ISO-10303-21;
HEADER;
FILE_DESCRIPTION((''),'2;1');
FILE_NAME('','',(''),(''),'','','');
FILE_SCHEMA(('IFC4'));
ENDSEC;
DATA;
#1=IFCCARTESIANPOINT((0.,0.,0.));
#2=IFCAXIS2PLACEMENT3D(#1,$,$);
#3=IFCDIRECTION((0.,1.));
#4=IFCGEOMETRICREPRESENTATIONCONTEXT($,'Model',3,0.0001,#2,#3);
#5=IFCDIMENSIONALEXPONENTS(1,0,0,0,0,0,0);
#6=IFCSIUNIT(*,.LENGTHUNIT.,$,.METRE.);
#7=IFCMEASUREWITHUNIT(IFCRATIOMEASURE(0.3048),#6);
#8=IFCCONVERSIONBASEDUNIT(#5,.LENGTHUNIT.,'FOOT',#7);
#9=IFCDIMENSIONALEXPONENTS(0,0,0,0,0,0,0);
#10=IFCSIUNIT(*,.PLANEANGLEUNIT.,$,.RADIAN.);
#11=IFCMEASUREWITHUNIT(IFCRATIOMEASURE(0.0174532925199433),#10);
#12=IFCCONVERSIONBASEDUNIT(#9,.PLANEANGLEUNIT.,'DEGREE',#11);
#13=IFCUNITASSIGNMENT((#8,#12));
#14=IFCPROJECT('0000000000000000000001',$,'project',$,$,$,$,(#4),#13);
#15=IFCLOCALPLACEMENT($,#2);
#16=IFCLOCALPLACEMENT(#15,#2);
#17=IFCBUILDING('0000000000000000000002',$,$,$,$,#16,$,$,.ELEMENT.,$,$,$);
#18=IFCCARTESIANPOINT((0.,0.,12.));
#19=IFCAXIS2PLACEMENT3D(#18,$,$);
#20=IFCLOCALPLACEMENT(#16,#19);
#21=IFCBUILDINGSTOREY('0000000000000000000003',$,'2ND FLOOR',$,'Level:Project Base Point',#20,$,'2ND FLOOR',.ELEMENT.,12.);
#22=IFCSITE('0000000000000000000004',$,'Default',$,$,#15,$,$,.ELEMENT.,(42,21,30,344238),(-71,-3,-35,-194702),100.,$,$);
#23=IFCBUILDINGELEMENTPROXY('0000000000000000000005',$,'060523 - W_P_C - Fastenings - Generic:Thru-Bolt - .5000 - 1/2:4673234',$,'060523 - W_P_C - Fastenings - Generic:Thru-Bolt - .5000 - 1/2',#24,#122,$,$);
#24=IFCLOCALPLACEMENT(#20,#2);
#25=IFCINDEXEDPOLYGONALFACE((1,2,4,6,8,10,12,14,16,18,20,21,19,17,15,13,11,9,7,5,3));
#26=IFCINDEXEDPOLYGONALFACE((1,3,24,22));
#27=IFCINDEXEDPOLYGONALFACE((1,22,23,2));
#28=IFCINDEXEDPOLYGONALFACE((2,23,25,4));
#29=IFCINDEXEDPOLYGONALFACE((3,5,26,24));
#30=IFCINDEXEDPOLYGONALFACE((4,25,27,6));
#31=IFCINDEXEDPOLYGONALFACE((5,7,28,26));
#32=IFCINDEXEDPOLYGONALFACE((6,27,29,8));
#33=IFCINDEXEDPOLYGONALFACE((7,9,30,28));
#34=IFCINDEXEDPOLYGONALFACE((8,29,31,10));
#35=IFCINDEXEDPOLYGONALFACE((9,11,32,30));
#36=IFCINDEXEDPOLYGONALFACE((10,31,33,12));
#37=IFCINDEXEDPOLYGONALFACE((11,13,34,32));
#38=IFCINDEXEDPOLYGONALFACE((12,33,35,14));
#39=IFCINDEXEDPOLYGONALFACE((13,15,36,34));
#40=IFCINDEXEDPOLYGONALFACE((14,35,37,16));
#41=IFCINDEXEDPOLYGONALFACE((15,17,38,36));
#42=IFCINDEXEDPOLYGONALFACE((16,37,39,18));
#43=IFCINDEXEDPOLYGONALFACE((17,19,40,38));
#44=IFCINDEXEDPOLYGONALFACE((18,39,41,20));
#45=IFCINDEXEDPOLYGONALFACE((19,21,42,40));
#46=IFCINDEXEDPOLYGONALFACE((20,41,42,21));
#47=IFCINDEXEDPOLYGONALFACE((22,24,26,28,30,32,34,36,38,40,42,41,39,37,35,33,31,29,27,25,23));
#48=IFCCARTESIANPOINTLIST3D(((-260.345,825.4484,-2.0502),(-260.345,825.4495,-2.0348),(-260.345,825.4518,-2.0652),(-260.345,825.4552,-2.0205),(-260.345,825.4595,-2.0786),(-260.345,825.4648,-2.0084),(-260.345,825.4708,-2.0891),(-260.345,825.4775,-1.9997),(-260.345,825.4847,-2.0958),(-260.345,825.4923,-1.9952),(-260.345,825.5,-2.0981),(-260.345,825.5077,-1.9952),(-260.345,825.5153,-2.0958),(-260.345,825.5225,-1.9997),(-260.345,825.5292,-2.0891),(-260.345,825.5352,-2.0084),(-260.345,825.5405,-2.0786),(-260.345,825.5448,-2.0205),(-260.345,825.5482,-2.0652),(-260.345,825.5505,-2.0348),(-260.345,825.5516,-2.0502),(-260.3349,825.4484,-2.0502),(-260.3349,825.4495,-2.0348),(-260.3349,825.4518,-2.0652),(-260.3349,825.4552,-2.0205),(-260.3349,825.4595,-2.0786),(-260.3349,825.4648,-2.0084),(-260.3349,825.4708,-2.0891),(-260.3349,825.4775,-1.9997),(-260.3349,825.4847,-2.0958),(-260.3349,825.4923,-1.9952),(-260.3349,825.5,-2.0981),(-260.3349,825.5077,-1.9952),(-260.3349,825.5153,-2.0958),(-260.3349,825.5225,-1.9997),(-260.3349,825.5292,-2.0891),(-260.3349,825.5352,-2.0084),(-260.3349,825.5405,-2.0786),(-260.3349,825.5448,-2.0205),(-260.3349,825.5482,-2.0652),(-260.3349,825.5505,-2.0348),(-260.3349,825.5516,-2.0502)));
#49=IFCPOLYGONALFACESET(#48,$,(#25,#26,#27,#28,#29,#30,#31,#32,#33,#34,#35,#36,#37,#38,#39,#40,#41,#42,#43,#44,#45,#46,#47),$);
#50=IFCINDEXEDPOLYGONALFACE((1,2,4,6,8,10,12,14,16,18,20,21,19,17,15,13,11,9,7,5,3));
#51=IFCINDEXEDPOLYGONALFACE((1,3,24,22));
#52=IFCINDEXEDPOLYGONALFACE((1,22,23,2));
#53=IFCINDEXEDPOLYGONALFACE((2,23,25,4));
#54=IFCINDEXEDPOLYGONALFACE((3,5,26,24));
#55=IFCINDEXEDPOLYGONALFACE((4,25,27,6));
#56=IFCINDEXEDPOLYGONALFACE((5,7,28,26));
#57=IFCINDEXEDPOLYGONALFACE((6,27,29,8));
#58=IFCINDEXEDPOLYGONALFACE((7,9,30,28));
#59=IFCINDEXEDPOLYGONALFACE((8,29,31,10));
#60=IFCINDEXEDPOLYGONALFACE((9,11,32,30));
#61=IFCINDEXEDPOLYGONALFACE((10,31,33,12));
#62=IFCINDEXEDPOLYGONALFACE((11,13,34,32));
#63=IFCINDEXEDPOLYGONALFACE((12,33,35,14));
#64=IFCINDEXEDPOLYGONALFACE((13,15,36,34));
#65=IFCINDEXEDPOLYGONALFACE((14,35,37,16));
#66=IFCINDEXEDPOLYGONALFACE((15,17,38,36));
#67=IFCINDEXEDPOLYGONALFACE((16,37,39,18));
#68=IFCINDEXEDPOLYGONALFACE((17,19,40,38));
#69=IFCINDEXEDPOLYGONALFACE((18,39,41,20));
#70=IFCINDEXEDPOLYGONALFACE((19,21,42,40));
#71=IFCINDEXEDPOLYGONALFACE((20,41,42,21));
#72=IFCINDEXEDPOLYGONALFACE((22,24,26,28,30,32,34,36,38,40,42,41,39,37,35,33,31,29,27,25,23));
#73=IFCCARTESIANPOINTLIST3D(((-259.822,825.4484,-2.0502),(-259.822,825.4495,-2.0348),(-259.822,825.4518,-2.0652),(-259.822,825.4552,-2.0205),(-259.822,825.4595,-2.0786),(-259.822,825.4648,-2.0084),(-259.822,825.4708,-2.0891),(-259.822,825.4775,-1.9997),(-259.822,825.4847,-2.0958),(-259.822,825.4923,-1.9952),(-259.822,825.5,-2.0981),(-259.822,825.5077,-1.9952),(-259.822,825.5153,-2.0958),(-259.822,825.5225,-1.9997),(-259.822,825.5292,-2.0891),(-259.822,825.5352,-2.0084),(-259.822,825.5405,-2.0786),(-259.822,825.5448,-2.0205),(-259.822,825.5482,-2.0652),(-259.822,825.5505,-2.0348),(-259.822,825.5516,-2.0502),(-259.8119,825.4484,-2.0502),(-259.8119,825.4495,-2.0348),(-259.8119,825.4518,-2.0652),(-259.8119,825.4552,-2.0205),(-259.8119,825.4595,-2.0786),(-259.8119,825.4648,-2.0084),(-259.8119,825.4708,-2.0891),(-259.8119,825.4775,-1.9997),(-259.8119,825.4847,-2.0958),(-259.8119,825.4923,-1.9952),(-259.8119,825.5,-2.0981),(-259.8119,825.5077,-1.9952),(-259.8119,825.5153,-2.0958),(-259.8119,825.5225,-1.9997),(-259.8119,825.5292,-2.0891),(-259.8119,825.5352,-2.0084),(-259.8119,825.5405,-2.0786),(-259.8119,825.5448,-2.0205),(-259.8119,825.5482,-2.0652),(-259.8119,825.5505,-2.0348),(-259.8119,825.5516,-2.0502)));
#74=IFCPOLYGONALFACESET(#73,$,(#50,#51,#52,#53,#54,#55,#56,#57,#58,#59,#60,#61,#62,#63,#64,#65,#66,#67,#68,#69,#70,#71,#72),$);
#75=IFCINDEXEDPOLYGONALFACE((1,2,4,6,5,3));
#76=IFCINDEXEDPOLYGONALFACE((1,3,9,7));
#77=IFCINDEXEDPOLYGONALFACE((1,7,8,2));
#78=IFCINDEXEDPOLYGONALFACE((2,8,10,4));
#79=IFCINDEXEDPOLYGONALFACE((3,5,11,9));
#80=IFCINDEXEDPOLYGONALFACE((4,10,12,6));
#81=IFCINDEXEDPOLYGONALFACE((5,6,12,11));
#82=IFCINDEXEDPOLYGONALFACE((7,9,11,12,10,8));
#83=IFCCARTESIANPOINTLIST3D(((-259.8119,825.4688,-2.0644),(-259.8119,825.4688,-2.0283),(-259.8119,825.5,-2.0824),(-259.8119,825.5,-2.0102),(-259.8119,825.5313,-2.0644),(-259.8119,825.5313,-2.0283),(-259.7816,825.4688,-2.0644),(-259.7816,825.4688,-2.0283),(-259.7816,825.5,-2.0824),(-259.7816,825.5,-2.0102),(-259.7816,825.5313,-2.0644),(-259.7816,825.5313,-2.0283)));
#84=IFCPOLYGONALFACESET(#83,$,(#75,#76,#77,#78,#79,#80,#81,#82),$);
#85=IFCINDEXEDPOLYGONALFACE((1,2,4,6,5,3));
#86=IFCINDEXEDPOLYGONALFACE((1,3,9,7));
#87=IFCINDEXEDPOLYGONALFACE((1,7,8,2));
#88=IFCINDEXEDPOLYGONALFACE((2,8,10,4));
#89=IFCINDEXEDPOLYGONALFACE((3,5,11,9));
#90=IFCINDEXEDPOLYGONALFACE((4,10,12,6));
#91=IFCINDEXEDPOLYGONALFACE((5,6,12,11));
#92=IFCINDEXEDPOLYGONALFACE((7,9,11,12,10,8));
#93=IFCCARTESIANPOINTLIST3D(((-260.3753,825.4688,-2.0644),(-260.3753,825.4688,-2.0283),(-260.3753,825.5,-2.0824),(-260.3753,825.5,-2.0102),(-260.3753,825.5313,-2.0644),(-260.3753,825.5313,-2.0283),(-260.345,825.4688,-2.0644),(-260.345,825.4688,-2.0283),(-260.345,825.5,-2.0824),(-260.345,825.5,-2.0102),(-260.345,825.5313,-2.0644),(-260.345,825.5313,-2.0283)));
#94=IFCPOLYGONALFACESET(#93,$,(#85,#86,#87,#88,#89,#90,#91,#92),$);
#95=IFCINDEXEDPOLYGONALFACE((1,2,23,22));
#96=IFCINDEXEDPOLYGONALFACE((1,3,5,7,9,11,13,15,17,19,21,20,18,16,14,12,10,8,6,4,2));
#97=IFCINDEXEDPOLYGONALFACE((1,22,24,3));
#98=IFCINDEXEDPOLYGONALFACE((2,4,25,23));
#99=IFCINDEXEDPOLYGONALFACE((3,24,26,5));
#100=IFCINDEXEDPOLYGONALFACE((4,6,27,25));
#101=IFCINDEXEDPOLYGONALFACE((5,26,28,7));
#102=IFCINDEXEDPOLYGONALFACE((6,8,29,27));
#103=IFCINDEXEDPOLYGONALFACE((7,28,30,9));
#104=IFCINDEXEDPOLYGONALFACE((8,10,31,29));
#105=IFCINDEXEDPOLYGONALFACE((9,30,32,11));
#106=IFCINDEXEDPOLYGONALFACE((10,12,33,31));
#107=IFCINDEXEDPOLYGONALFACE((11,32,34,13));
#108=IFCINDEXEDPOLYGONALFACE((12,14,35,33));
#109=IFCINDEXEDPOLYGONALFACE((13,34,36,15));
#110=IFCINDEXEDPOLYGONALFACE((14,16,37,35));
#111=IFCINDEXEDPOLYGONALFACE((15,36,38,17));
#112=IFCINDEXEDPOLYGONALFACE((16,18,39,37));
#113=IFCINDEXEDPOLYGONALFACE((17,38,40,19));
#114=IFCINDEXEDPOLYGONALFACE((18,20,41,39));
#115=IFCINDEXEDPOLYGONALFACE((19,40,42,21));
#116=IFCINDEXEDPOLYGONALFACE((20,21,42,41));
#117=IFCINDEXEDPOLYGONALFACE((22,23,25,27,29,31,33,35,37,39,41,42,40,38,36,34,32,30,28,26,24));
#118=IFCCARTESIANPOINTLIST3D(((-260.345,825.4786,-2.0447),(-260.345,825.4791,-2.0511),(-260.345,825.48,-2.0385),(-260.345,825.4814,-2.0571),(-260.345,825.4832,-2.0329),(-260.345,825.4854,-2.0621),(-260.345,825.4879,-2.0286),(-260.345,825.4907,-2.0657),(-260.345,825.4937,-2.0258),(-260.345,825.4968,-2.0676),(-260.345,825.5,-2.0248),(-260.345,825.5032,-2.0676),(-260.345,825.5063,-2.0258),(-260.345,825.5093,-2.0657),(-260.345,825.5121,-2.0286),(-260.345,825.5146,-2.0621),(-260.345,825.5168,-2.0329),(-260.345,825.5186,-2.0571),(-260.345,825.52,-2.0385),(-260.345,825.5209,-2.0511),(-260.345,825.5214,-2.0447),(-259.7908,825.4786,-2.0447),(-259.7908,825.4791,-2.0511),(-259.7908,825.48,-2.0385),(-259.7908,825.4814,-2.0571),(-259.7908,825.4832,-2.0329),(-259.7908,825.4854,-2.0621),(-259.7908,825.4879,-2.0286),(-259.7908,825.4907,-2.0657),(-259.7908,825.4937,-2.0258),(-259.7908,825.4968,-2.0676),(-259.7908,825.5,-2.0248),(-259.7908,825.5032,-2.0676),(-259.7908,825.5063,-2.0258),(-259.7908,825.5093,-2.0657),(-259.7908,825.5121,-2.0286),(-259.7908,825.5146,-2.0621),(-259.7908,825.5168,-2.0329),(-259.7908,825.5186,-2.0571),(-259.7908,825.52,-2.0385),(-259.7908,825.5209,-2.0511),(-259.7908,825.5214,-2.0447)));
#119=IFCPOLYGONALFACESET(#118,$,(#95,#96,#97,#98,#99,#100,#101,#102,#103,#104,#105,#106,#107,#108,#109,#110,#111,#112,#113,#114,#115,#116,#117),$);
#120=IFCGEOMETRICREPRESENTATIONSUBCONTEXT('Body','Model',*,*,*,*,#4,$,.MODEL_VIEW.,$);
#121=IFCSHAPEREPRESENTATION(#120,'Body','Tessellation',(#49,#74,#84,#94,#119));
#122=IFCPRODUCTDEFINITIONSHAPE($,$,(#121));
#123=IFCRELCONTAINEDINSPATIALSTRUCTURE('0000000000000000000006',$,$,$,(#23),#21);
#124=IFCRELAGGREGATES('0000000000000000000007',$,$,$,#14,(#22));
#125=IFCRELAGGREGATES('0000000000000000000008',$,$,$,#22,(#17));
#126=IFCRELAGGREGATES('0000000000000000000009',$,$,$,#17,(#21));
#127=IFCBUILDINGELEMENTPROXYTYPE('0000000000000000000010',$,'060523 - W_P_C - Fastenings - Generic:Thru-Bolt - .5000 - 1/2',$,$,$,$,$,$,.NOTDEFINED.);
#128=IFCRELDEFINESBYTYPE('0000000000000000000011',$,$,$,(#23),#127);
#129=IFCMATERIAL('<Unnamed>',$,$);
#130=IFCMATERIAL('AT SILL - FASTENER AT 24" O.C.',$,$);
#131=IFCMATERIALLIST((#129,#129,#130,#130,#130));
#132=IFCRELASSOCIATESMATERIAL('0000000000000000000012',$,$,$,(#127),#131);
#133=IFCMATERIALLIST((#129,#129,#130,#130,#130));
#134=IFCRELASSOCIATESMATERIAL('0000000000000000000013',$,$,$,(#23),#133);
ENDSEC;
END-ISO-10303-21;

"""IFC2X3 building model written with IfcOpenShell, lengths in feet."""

from ifc_helpers import new_model, entity, si_unit, converted_unit, direction, frame, frame_2d, origin, place, context, subcontext, project, spatial, polyline, circle, outline, extrude, source, transform, mapped, material, material_list, type_object, type_shapes, element, save


model = new_model("IFC2X3")

# Units and contexts
model_context = context("Model", 3, precision=0.0001, world=origin(), true_north=direction((0.0, 1.0)))
body_context = subcontext(model_context, "Body", "Model", "MODEL_VIEW")
ifc_project = project(units=[converted_unit("LENGTHUNIT", "FOOT", entity("IfcRatioMeasure", 0.3048), si_unit("LENGTHUNIT", "METRE"), dimensions=[1, 0, 0, 0, 0, 0, 0]), converted_unit("PLANEANGLEUNIT", "DEGREE", entity("IfcRatioMeasure", 0.0174532925199433), si_unit("PLANEANGLEUNIT", "RADIAN"), dimensions=[0, 0, 0, 0, 0, 0, 0])], contexts=[model_context])

# Site, building, storey
site_placement = place(None, origin())
site = spatial("IfcSite", under=ifc_project, at=site_placement, Name="Default", CompositionType="ELEMENT", RefLatitude=(42, 21, 30, 344238), RefLongitude=(-71, -3, -35, -194702), RefElevation=100.0)
building_placement = place(site_placement, origin())
building = spatial("IfcBuilding", under=site, at=building_placement, CompositionType="ELEMENT")
storey_placement = place(building_placement, frame((0.0, 0.0, 12.0)))
storey = spatial("IfcBuildingStorey", under=building, at=storey_placement, Name="2ND FLOOR", ObjectType="Level:Project Base Point", LongName="2ND FLOOR", CompositionType="ELEMENT", Elevation=12.0)

# Building element proxy
ifc_material_1 = material(Name="<Unnamed>")
ifc_material_2 = material(Name="AT SILL - FASTENER AT 24\" O.C.")
ifc_material_list_1 = material_list([ifc_material_1, ifc_material_1, ifc_material_2, ifc_material_2, ifc_material_2])
ifc_material_list_2 = material_list([ifc_material_1, ifc_material_1, ifc_material_2, ifc_material_2, ifc_material_2])
building_element_proxy_type_1 = type_object("IfcBuildingElementProxyType", Name="060523 - W_P_C - Fastenings - Generic:Thru-Bolt - .5000 - 1/2", PredefinedType="NOTDEFINED", material=ifc_material_list_2)
shared_shape_1 = source(origin(), body_context, "Body", "SweptSolid", [
    extrude(circle(Radius=0.0518, at=frame_2d((0.0, 0.0), x_axis=(1.0, 0.0))), frame((0.0, 0.0, 0.0), z_axis=(0.0, 0.0, 1.0), x_axis=(0.0, 1.0, 0.0)), (0.0, 0.0, 1.0), 0.0101),
    extrude(circle(Radius=0.0518, at=frame_2d((0.0, 0.0), x_axis=(1.0, 0.0))), frame((0.0, 0.0, -0.523), z_axis=(0.0, 0.0, 1.0), x_axis=(0.0, 1.0, 0.0)), (0.0, 0.0, 1.0), 0.0101),
    extrude(outline(polyline([(-0.018, -0.0313), (0.018, -0.0313), (0.0361, 0.0), (0.018, 0.0313), (-0.018, 0.0313), (-0.0361, 0.0), (-0.018, -0.0313)])), frame((0.0, 0.0, -0.5533), z_axis=(0.0, 0.0, 1.0), x_axis=(0.0, -1.0, 0.0)), (0.0, 0.0, 1.0), 0.0303),
    extrude(outline(polyline([(-0.018, -0.0313), (0.018, -0.0313), (0.0361, 0.0), (0.018, 0.0312), (-0.018, 0.0312), (-0.0361, 0.0), (-0.018, -0.0313)])), frame((0.0, 0.0, 0.0101), z_axis=(0.0, 0.0, 1.0), x_axis=(0.866025, -0.5, 0.0)), (0.0, 0.0, 1.0), 0.0303),
    extrude(circle(Radius=0.0215, at=frame_2d((0.0, 0.0), x_axis=(1.0, 0.0))), frame((0.0, 0.0, -0.5442), z_axis=(0.0, 0.0, 1.0), x_axis=(0.0, -1.0, 0.0)), (0.0, 0.0, 1.0), 0.5543),
])
type_shapes(building_element_proxy_type_1, [shared_shape_1])
proxy_1_placement = place(storey_placement, frame((-260.3349, 825.5, -2.0463), z_axis=(-1.0, 0.0, 0.0), x_axis=(0.0, 1.0, 0.0)))
element("IfcBuildingElementProxy", 1, at=proxy_1_placement, inside=storey, type_object=building_element_proxy_type_1, material=ifc_material_list_1, Name="060523 - W_P_C - Fastenings - Generic:Thru-Bolt - .5000 - 1/2:4673234", ObjectType="060523 - W_P_C - Fastenings - Generic:Thru-Bolt - .5000 - 1/2", context=body_context, shape_type="MappedRepresentation", body=[
    mapped(shared_shape_1, transform((0.0, 0.0, 0.0), scale=1.0)),
])

save(model, "model.ifc")
